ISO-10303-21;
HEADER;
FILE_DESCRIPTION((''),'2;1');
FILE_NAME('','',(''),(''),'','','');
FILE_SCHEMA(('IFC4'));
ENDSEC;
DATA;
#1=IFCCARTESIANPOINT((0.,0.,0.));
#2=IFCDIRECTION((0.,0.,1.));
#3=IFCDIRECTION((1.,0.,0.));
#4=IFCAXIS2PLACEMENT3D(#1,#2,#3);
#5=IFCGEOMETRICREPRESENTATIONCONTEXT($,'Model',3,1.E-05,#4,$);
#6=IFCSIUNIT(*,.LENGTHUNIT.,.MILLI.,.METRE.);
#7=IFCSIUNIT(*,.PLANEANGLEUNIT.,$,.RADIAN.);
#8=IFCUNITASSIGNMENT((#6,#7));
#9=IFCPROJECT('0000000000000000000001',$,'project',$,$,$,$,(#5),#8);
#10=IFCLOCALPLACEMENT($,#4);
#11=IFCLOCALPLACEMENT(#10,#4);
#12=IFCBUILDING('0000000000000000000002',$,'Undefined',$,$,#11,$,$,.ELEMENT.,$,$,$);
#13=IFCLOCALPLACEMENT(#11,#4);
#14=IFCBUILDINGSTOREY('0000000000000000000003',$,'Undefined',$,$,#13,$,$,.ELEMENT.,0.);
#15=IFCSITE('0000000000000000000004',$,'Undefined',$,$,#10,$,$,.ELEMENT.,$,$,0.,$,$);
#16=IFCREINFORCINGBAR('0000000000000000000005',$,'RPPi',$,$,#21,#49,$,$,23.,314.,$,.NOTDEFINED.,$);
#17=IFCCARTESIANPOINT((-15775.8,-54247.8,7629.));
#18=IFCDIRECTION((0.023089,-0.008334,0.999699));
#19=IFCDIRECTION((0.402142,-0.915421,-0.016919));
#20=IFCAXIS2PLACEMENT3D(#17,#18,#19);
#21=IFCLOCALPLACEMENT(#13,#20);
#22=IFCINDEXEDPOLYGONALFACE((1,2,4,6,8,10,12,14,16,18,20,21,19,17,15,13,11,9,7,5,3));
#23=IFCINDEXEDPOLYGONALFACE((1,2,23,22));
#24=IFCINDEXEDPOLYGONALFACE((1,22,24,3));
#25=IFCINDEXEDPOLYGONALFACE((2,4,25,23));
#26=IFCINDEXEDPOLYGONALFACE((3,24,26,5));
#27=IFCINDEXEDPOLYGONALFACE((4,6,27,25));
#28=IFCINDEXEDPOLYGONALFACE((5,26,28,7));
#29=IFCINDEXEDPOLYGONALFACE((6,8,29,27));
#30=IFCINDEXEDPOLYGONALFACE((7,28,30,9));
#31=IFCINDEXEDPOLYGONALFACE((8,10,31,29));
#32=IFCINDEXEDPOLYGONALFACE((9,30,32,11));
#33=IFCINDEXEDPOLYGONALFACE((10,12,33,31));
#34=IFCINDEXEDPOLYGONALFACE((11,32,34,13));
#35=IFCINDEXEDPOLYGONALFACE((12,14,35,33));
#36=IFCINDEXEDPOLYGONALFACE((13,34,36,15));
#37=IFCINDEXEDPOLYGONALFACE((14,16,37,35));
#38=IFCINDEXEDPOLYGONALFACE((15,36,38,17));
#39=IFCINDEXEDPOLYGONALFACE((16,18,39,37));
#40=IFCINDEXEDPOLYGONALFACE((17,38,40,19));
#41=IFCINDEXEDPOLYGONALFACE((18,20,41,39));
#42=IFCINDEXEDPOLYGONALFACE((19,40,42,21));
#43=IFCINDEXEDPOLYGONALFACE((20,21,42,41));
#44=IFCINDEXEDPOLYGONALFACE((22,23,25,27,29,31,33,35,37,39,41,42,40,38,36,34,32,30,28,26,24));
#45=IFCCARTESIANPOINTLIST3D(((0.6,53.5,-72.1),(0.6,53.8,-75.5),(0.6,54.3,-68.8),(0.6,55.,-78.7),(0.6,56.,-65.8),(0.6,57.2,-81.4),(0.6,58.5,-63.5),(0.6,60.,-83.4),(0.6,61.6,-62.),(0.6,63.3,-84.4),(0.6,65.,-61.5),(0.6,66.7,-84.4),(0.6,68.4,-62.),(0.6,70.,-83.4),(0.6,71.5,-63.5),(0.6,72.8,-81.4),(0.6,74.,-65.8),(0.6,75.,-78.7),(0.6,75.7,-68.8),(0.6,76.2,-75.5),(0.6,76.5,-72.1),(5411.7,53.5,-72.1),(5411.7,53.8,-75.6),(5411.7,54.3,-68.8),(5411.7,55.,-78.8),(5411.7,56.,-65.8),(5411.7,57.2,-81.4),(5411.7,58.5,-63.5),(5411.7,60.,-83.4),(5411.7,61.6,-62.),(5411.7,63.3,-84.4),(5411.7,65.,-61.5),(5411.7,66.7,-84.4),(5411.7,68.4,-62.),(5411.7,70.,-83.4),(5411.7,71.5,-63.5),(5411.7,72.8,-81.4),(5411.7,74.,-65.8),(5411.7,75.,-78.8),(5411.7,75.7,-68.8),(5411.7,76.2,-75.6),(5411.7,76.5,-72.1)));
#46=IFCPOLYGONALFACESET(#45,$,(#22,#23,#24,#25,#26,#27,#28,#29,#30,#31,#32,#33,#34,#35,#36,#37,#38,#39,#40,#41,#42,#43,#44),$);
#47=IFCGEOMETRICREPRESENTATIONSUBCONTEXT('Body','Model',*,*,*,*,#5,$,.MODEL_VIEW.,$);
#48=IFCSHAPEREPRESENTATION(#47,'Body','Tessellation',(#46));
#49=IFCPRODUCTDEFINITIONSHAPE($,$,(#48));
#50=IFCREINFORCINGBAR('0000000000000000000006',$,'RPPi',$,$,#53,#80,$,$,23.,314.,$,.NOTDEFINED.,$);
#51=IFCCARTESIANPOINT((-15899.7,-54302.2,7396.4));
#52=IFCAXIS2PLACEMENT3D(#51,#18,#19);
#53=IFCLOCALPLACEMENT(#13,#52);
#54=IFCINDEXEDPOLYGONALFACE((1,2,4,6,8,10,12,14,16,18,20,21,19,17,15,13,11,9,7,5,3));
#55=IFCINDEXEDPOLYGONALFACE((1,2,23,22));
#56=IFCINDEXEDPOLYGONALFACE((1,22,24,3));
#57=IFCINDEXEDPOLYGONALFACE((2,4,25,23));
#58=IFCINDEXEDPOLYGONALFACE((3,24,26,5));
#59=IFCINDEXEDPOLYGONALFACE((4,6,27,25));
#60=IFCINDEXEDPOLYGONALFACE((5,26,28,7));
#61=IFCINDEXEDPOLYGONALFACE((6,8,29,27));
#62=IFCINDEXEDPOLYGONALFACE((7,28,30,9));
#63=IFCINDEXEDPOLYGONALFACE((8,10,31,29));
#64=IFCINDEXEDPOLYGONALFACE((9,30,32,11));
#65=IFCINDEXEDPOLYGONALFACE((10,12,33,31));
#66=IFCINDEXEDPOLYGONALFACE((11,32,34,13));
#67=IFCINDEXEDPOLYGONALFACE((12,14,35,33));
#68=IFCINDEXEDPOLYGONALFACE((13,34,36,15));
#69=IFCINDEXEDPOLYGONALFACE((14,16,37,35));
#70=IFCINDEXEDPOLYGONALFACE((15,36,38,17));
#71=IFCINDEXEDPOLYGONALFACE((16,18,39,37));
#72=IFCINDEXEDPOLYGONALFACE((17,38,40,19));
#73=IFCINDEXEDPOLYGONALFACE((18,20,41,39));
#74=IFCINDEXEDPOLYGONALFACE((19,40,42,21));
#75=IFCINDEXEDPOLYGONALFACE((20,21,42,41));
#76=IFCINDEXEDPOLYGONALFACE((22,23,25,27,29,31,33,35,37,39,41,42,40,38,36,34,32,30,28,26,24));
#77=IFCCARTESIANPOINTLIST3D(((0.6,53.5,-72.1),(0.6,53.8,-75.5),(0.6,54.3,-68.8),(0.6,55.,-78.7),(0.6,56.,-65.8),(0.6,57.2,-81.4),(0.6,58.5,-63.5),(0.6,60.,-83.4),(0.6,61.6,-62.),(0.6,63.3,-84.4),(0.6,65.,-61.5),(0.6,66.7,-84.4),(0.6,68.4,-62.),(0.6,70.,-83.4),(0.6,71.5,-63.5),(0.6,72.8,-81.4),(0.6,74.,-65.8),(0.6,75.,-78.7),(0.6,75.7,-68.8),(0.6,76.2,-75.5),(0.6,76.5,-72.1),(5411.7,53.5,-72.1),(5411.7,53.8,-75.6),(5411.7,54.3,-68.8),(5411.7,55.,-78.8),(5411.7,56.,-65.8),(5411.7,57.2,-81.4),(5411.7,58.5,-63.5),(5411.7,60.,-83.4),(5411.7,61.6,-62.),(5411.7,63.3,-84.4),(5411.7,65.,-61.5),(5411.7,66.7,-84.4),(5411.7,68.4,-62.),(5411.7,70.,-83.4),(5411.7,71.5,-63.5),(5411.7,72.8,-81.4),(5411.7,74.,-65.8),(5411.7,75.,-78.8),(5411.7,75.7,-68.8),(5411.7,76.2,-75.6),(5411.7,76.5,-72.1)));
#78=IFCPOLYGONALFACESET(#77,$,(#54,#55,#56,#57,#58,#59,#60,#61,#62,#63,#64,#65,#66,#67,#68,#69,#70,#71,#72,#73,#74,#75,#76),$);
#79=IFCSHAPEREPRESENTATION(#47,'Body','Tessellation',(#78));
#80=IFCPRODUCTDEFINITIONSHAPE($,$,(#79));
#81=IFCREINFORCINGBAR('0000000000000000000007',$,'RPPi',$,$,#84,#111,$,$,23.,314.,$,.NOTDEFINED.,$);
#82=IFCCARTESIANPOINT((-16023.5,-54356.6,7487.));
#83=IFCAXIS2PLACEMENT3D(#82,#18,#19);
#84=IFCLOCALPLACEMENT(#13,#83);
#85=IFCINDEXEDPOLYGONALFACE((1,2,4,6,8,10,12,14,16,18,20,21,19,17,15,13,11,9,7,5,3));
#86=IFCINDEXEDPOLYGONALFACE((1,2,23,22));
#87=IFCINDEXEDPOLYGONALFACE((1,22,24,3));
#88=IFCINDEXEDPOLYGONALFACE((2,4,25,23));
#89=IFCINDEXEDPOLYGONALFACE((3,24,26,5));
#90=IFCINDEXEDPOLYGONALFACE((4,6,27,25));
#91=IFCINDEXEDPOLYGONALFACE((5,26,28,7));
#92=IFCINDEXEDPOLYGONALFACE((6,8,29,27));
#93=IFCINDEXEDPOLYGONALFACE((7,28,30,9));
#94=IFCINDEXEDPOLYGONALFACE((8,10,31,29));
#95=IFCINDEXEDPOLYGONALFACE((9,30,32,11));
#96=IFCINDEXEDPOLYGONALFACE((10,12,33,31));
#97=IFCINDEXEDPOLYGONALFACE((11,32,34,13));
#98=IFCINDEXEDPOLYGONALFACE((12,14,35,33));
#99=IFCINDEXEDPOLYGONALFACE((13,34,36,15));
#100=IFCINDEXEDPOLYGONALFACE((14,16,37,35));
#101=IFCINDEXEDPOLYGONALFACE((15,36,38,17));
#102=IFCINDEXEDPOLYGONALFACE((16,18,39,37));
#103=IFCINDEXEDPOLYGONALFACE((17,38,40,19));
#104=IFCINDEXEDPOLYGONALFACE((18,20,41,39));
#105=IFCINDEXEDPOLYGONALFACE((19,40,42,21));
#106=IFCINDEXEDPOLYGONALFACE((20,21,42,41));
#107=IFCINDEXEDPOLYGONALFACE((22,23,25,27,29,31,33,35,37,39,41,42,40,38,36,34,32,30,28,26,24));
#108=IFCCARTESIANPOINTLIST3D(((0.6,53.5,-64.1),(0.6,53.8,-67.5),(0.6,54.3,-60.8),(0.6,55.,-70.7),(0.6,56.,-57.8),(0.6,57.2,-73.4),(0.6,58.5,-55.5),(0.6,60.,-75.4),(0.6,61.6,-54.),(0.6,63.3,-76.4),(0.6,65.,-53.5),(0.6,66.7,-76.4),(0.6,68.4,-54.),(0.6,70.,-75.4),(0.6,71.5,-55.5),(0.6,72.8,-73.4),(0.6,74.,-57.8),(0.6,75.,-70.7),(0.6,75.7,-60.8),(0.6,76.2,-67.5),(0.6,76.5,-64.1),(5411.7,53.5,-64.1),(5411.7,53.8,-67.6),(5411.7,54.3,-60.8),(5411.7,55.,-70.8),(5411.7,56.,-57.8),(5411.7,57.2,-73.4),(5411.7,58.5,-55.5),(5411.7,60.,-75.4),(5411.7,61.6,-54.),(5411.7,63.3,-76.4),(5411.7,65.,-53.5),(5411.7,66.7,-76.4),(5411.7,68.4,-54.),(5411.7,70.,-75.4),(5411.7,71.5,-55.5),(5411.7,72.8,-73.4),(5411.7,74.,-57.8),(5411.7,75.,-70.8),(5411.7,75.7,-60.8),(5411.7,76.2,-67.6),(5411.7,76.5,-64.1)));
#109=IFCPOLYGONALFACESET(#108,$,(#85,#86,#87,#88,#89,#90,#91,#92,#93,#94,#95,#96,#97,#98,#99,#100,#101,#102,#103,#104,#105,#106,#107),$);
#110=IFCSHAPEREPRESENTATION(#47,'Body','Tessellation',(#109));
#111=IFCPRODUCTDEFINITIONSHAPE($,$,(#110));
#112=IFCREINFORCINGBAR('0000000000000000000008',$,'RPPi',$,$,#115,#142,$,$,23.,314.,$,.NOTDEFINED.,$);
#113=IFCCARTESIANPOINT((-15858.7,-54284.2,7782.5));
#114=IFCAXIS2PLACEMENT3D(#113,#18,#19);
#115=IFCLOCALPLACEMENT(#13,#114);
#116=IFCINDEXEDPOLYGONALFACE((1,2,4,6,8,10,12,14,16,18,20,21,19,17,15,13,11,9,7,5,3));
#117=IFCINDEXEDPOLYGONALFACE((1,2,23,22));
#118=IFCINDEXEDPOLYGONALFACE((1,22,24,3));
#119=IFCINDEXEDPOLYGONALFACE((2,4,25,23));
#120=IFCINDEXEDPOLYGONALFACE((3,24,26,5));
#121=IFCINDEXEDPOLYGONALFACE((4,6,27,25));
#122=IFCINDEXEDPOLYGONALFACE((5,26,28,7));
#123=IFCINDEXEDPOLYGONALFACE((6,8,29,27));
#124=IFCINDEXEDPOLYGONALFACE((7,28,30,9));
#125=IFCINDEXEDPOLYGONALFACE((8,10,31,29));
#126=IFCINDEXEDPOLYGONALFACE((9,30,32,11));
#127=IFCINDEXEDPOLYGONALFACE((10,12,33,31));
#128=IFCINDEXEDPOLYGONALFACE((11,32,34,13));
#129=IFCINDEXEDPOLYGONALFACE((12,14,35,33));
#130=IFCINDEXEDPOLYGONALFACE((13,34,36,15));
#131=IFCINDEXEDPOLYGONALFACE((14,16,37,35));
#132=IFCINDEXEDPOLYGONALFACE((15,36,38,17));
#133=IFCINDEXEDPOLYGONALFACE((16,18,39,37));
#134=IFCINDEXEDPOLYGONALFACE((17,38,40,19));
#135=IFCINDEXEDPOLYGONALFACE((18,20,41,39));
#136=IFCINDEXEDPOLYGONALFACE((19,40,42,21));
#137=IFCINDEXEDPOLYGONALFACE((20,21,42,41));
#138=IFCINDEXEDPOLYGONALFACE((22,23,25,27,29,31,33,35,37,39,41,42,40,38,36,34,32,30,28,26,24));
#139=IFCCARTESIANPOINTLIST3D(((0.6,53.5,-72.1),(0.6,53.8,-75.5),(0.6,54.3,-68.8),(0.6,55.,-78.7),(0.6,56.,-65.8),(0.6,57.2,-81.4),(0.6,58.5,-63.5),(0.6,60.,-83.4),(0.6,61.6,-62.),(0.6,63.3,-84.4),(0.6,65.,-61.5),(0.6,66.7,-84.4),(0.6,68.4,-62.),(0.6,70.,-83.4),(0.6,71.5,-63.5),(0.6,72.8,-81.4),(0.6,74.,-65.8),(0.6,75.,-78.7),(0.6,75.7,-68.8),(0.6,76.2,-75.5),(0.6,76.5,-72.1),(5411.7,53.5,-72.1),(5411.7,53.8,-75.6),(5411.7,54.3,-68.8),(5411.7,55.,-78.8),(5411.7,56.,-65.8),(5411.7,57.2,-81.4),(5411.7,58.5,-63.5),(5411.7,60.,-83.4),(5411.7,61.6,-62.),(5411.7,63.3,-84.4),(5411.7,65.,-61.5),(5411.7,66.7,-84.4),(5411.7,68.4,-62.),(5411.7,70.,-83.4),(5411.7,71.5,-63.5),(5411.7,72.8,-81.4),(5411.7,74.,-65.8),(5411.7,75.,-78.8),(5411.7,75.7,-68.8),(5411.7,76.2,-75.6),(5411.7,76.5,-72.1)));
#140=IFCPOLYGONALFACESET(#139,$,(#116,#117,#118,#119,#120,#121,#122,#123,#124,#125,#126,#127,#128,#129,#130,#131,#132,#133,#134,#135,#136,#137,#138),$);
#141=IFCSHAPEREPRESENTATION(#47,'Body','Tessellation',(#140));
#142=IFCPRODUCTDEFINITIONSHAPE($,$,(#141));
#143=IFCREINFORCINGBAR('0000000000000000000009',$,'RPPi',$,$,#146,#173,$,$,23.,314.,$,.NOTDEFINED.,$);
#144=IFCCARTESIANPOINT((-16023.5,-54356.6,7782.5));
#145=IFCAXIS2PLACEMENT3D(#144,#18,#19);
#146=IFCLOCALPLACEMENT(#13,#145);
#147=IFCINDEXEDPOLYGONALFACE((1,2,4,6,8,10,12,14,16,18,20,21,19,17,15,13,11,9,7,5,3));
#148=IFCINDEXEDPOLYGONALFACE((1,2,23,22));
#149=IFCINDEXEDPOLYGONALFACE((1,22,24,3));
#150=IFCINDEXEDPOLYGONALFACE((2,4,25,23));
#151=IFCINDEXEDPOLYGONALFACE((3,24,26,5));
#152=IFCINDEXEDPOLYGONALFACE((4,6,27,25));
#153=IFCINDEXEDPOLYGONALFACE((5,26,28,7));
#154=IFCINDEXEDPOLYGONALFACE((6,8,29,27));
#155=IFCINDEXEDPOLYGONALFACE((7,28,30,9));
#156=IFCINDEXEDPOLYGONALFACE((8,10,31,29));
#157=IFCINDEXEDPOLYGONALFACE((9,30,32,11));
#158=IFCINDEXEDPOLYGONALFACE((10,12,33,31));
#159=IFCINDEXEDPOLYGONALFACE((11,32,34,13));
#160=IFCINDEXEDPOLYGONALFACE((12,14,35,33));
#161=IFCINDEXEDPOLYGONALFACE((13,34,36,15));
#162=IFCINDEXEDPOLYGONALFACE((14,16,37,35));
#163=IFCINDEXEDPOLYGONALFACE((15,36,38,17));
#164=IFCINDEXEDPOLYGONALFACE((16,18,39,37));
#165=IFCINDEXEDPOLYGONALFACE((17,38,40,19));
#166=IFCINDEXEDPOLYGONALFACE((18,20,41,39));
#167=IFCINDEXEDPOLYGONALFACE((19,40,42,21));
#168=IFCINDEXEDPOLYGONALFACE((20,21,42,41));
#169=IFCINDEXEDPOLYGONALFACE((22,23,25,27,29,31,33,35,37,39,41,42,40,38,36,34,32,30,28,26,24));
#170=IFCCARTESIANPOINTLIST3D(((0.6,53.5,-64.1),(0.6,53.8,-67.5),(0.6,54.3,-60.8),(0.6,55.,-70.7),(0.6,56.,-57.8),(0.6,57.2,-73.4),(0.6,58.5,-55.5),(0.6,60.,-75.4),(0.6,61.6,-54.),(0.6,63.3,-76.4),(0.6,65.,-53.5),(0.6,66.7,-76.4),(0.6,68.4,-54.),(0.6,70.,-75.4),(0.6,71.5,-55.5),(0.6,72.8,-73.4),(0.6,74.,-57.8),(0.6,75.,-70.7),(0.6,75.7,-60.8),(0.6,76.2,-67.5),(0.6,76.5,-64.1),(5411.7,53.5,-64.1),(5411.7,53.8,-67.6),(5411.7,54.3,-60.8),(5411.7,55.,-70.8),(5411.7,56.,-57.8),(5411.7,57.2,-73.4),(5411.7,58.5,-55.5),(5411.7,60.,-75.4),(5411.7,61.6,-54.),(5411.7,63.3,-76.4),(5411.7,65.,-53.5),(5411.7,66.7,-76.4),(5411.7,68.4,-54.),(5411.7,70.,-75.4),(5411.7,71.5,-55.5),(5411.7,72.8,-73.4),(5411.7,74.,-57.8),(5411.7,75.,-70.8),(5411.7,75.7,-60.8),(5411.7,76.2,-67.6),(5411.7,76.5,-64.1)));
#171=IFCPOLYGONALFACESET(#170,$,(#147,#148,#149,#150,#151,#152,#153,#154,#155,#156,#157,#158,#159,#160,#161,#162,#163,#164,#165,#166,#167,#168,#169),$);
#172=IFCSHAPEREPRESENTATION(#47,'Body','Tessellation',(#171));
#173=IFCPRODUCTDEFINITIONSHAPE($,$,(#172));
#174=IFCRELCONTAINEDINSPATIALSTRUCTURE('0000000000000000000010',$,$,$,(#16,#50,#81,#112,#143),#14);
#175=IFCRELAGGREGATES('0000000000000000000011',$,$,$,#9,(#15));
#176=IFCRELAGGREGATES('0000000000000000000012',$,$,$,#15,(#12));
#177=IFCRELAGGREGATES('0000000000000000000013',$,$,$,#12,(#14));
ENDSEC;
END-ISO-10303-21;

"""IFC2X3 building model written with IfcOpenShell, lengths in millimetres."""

from ifc_helpers import new_model, entity, si_unit, frame, origin_with_axes, place, context, subcontext, project, spatial, source, transform, mapped, element, save


model = new_model("IFC2X3")

# Units and contexts
model_context = context("Model", 3, precision=1e-05, world=origin_with_axes())
body_context = subcontext(model_context, "Body", "Model", "MODEL_VIEW")
ifc_project = project(units=[si_unit("LENGTHUNIT", "METRE", prefix="MILLI"), si_unit("PLANEANGLEUNIT", "RADIAN")], contexts=[model_context])

# Site, building, storey
site_placement = place(None, origin_with_axes())
site = spatial("IfcSite", under=ifc_project, at=site_placement, Name="Undefined", CompositionType="ELEMENT", RefElevation=0.0)
building_placement = place(site_placement, origin_with_axes())
building = spatial("IfcBuilding", under=site, at=building_placement, Name="Undefined", CompositionType="ELEMENT")
storey_placement = place(building_placement, origin_with_axes())
storey = spatial("IfcBuildingStorey", under=building, at=storey_placement, Name="Undefined", CompositionType="ELEMENT", Elevation=0.0)

# Reinforcing bars
shared_shape_1 = source(origin_with_axes(), body_context, "Body", "AdvancedSweptSolid", [
    entity("IfcSweptDiskSolid", entity("IfcTrimmedCurve", entity("IfcLine", entity("IfcCartesianPoint", [0.0, 0.0, 0.0]), entity("IfcVector", entity("IfcDirection", [1.0, 0.0, -0.000002]), 1.0)), [entity("IfcParameterValue", 0.0)], [entity("IfcParameterValue", 5411.092317)], True, "PARAMETER"), 11.5, None, 0.0, 5411.1),
])
reinforcing_bar_1_placement = place(storey_placement, frame((-15775.8, -54247.8, 7629.0), z_axis=(0.023089, -0.008334, 0.999699), x_axis=(0.402142, -0.915421, -0.016919)))
element("IfcReinforcingBar", 1, at=reinforcing_bar_1_placement, inside=storey, Name="RPPi", BarRole="NOTDEFINED", CrossSectionArea=314.0, NominalDiameter=23.0, context=body_context, shape_type="MappedRepresentation", body=[
    mapped(shared_shape_1, transform((0.6, 65.0, -73.0))),
])
shared_shape_2 = source(origin_with_axes(), body_context, "Body", "AdvancedSweptSolid", [
    entity("IfcSweptDiskSolid", entity("IfcTrimmedCurve", entity("IfcLine", entity("IfcCartesianPoint", [0.0, 0.0, 0.0]), entity("IfcVector", entity("IfcDirection", [1.0, 0.0, -0.000002]), 1.0)), [entity("IfcParameterValue", 0.0)], [entity("IfcParameterValue", 5411.092317)], True, "PARAMETER"), 11.5, None, 0.0, 5411.1),
])
reinforcing_bar_2_placement = place(storey_placement, frame((-15899.7, -54302.2, 7396.4), z_axis=(0.023089, -0.008334, 0.999699), x_axis=(0.402142, -0.915421, -0.016919)))
element("IfcReinforcingBar", 2, at=reinforcing_bar_2_placement, inside=storey, Name="RPPi", BarRole="NOTDEFINED", CrossSectionArea=314.0, NominalDiameter=23.0, context=body_context, shape_type="MappedRepresentation", body=[
    mapped(shared_shape_2, transform((0.6, 65.0, -73.0))),
])
shared_shape_3 = source(origin_with_axes(), body_context, "Body", "AdvancedSweptSolid", [
    entity("IfcSweptDiskSolid", entity("IfcTrimmedCurve", entity("IfcLine", entity("IfcCartesianPoint", [0.0, 0.0, 0.0]), entity("IfcVector", entity("IfcDirection", [1.0, 0.0, -0.000002]), 1.0)), [entity("IfcParameterValue", 0.0)], [entity("IfcParameterValue", 5411.092317)], True, "PARAMETER"), 11.5, None, 0.0, 5411.1),
])
reinforcing_bar_3_placement = place(storey_placement, frame((-16023.5, -54356.6, 7487.0), z_axis=(0.023089, -0.008334, 0.999699), x_axis=(0.402142, -0.915421, -0.016919)))
element("IfcReinforcingBar", 3, at=reinforcing_bar_3_placement, inside=storey, Name="RPPi", BarRole="NOTDEFINED", CrossSectionArea=314.0, NominalDiameter=23.0, context=body_context, shape_type="MappedRepresentation", body=[
    mapped(shared_shape_3, transform((0.6, 65.0, -65.0))),
])
shared_shape_4 = source(origin_with_axes(), body_context, "Body", "AdvancedSweptSolid", [
    entity("IfcSweptDiskSolid", entity("IfcTrimmedCurve", entity("IfcLine", entity("IfcCartesianPoint", [0.0, 0.0, 0.0]), entity("IfcVector", entity("IfcDirection", [1.0, 0.0, -0.000002]), 1.0)), [entity("IfcParameterValue", 0.0)], [entity("IfcParameterValue", 5411.092317)], True, "PARAMETER"), 11.5, None, 0.0, 5411.1),
])
reinforcing_bar_4_placement = place(storey_placement, frame((-15858.7, -54284.2, 7782.5), z_axis=(0.023089, -0.008334, 0.999699), x_axis=(0.402142, -0.915421, -0.016919)))
element("IfcReinforcingBar", 4, at=reinforcing_bar_4_placement, inside=storey, Name="RPPi", BarRole="NOTDEFINED", CrossSectionArea=314.0, NominalDiameter=23.0, context=body_context, shape_type="MappedRepresentation", body=[
    mapped(shared_shape_4, transform((0.6, 65.0, -73.0))),
])
shared_shape_5 = source(origin_with_axes(), body_context, "Body", "AdvancedSweptSolid", [
    entity("IfcSweptDiskSolid", entity("IfcTrimmedCurve", entity("IfcLine", entity("IfcCartesianPoint", [0.0, 0.0, 0.0]), entity("IfcVector", entity("IfcDirection", [1.0, 0.0, -0.000002]), 1.0)), [entity("IfcParameterValue", 0.0)], [entity("IfcParameterValue", 5411.092317)], True, "PARAMETER"), 11.5, None, 0.0, 5411.1),
])
reinforcing_bar_5_placement = place(storey_placement, frame((-16023.5, -54356.6, 7782.5), z_axis=(0.023089, -0.008334, 0.999699), x_axis=(0.402142, -0.915421, -0.016919)))
element("IfcReinforcingBar", 5, at=reinforcing_bar_5_placement, inside=storey, Name="RPPi", BarRole="NOTDEFINED", CrossSectionArea=314.0, NominalDiameter=23.0, context=body_context, shape_type="MappedRepresentation", body=[
    mapped(shared_shape_5, transform((0.6, 65.0, -65.0))),
])

save(model, "model.ifc")
